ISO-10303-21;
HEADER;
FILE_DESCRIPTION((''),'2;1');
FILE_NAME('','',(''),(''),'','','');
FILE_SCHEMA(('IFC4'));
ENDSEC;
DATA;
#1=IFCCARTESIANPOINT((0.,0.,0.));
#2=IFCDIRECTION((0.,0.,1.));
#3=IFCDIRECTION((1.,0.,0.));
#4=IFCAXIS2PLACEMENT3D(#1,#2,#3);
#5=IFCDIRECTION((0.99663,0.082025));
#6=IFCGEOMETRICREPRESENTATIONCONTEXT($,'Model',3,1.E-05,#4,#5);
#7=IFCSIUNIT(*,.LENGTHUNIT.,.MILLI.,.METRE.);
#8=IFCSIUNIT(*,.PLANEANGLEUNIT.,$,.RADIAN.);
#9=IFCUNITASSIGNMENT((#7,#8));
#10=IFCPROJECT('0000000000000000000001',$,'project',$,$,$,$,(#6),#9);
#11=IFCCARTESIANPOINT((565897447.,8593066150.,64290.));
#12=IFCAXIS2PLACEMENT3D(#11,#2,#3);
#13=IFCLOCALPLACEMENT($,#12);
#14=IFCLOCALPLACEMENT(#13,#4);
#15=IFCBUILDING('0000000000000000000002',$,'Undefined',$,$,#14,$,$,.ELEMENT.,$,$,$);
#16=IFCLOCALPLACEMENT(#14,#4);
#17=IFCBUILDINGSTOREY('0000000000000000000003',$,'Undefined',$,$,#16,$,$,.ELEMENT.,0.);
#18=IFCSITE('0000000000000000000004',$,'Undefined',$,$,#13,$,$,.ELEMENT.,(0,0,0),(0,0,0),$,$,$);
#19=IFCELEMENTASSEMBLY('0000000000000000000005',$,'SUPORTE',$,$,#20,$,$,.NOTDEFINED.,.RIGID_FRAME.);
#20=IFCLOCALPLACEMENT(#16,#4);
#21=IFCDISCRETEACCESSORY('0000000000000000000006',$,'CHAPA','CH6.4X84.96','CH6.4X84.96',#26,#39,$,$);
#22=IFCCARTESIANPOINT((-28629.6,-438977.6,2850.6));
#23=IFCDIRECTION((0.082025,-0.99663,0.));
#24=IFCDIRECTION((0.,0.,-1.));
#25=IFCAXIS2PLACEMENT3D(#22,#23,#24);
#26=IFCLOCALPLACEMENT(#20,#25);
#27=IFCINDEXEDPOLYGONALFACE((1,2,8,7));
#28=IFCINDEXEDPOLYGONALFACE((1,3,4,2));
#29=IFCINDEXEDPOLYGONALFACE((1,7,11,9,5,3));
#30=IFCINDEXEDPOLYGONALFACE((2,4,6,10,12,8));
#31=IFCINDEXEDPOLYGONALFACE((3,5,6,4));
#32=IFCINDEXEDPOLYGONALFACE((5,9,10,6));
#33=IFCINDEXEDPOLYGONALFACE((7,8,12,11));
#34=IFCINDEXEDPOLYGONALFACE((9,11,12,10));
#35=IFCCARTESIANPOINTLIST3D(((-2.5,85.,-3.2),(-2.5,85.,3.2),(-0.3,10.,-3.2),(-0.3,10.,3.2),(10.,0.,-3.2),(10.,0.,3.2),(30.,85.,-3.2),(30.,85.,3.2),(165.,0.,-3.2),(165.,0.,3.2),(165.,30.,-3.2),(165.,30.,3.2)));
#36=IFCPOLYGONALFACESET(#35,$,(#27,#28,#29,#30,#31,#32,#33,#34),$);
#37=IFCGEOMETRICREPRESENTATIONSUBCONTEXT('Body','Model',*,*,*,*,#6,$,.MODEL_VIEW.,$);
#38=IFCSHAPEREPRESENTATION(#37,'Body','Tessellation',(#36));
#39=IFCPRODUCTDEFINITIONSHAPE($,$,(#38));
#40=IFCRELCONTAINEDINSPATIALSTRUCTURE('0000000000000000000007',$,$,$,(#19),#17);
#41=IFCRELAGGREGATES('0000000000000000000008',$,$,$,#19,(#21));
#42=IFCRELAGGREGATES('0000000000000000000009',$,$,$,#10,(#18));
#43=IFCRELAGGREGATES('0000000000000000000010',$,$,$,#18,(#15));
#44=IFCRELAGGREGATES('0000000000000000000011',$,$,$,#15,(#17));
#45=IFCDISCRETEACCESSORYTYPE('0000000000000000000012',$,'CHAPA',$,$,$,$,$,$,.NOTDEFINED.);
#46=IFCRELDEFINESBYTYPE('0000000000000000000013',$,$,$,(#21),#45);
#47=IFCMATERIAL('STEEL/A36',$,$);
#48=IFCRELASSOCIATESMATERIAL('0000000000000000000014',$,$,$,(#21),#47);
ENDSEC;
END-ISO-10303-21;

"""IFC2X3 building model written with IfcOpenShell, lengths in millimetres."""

from ifc_helpers import new_model, si_unit, direction, frame, origin_with_axes, place, context, subcontext, project, spatial, polyline, outline, extrude, material, type_object, element, aggregate, save


model = new_model("IFC2X3")

# Units and contexts
model_context = context("Model", 3, precision=1e-05, world=origin_with_axes(), true_north=direction((0.99663, 0.082025)))
body_context = subcontext(model_context, "Body", "Model", "MODEL_VIEW")
ifc_project = project(units=[si_unit("LENGTHUNIT", "METRE", prefix="MILLI"), si_unit("PLANEANGLEUNIT", "RADIAN")], contexts=[model_context])

# Site, building, storey
site_placement = place(None, frame((565897447.0, 8593066150.0, 64290.0), z_axis=(0.0, 0.0, 1.0), x_axis=(1.0, 0.0, 0.0)))
site = spatial("IfcSite", under=ifc_project, at=site_placement, Name="Undefined", CompositionType="ELEMENT", RefLatitude=(0, 0, 0), RefLongitude=(0, 0, 0))
building_placement = place(site_placement, origin_with_axes())
building = spatial("IfcBuilding", under=site, at=building_placement, Name="Undefined", CompositionType="ELEMENT")
storey_placement = place(building_placement, origin_with_axes())
storey = spatial("IfcBuildingStorey", under=building, at=storey_placement, Name="Undefined", CompositionType="ELEMENT", Elevation=0.0)

# Shared definitions
ifc_material_1 = material(Name="STEEL/A36")

# Shared definitions
discrete_accessory_type_1 = type_object("IfcDiscreteAccessoryType", Name="CHAPA")

# Element assembly, discrete accessory
assembly_1_placement = place(storey_placement, origin_with_axes())
assembly_1 = element("IfcElementAssembly", 1, at=assembly_1_placement, inside=storey, Name="SUPORTE", AssemblyPlace="NOTDEFINED", PredefinedType="RIGID_FRAME")
discrete_accessory_1_placement = place(assembly_1_placement, frame((-28629.6, -438977.6, 2850.6), z_axis=(0.082025, -0.99663, 0.0), x_axis=(0.0, 0.0, -1.0)))
discrete_accessory_1 = element("IfcDiscreteAccessory", 2, at=discrete_accessory_1_placement, type_object=discrete_accessory_type_1, material=ifc_material_1, Name="CHAPA", Description="CH6.4X84.96", ObjectType="CH6.4X84.96", context=body_context, shape_type="SweptSolid", body=[
    extrude(outline(polyline([(-0.3, 10.0), (10.0, 0.0), (165.0, 0.0), (165.0, 30.0), (30.0, 85.0), (-2.5, 85.0), (-0.3, 10.0)])), frame((0.0, 0.0, -3.2), z_axis=(0.0, 0.0, 1.0), x_axis=(1.0, 0.0, 0.0)), (0.0, 0.0, 1.0), 6.4),
])
aggregate(assembly_1, [discrete_accessory_1])

save(model, "model.ifc")
